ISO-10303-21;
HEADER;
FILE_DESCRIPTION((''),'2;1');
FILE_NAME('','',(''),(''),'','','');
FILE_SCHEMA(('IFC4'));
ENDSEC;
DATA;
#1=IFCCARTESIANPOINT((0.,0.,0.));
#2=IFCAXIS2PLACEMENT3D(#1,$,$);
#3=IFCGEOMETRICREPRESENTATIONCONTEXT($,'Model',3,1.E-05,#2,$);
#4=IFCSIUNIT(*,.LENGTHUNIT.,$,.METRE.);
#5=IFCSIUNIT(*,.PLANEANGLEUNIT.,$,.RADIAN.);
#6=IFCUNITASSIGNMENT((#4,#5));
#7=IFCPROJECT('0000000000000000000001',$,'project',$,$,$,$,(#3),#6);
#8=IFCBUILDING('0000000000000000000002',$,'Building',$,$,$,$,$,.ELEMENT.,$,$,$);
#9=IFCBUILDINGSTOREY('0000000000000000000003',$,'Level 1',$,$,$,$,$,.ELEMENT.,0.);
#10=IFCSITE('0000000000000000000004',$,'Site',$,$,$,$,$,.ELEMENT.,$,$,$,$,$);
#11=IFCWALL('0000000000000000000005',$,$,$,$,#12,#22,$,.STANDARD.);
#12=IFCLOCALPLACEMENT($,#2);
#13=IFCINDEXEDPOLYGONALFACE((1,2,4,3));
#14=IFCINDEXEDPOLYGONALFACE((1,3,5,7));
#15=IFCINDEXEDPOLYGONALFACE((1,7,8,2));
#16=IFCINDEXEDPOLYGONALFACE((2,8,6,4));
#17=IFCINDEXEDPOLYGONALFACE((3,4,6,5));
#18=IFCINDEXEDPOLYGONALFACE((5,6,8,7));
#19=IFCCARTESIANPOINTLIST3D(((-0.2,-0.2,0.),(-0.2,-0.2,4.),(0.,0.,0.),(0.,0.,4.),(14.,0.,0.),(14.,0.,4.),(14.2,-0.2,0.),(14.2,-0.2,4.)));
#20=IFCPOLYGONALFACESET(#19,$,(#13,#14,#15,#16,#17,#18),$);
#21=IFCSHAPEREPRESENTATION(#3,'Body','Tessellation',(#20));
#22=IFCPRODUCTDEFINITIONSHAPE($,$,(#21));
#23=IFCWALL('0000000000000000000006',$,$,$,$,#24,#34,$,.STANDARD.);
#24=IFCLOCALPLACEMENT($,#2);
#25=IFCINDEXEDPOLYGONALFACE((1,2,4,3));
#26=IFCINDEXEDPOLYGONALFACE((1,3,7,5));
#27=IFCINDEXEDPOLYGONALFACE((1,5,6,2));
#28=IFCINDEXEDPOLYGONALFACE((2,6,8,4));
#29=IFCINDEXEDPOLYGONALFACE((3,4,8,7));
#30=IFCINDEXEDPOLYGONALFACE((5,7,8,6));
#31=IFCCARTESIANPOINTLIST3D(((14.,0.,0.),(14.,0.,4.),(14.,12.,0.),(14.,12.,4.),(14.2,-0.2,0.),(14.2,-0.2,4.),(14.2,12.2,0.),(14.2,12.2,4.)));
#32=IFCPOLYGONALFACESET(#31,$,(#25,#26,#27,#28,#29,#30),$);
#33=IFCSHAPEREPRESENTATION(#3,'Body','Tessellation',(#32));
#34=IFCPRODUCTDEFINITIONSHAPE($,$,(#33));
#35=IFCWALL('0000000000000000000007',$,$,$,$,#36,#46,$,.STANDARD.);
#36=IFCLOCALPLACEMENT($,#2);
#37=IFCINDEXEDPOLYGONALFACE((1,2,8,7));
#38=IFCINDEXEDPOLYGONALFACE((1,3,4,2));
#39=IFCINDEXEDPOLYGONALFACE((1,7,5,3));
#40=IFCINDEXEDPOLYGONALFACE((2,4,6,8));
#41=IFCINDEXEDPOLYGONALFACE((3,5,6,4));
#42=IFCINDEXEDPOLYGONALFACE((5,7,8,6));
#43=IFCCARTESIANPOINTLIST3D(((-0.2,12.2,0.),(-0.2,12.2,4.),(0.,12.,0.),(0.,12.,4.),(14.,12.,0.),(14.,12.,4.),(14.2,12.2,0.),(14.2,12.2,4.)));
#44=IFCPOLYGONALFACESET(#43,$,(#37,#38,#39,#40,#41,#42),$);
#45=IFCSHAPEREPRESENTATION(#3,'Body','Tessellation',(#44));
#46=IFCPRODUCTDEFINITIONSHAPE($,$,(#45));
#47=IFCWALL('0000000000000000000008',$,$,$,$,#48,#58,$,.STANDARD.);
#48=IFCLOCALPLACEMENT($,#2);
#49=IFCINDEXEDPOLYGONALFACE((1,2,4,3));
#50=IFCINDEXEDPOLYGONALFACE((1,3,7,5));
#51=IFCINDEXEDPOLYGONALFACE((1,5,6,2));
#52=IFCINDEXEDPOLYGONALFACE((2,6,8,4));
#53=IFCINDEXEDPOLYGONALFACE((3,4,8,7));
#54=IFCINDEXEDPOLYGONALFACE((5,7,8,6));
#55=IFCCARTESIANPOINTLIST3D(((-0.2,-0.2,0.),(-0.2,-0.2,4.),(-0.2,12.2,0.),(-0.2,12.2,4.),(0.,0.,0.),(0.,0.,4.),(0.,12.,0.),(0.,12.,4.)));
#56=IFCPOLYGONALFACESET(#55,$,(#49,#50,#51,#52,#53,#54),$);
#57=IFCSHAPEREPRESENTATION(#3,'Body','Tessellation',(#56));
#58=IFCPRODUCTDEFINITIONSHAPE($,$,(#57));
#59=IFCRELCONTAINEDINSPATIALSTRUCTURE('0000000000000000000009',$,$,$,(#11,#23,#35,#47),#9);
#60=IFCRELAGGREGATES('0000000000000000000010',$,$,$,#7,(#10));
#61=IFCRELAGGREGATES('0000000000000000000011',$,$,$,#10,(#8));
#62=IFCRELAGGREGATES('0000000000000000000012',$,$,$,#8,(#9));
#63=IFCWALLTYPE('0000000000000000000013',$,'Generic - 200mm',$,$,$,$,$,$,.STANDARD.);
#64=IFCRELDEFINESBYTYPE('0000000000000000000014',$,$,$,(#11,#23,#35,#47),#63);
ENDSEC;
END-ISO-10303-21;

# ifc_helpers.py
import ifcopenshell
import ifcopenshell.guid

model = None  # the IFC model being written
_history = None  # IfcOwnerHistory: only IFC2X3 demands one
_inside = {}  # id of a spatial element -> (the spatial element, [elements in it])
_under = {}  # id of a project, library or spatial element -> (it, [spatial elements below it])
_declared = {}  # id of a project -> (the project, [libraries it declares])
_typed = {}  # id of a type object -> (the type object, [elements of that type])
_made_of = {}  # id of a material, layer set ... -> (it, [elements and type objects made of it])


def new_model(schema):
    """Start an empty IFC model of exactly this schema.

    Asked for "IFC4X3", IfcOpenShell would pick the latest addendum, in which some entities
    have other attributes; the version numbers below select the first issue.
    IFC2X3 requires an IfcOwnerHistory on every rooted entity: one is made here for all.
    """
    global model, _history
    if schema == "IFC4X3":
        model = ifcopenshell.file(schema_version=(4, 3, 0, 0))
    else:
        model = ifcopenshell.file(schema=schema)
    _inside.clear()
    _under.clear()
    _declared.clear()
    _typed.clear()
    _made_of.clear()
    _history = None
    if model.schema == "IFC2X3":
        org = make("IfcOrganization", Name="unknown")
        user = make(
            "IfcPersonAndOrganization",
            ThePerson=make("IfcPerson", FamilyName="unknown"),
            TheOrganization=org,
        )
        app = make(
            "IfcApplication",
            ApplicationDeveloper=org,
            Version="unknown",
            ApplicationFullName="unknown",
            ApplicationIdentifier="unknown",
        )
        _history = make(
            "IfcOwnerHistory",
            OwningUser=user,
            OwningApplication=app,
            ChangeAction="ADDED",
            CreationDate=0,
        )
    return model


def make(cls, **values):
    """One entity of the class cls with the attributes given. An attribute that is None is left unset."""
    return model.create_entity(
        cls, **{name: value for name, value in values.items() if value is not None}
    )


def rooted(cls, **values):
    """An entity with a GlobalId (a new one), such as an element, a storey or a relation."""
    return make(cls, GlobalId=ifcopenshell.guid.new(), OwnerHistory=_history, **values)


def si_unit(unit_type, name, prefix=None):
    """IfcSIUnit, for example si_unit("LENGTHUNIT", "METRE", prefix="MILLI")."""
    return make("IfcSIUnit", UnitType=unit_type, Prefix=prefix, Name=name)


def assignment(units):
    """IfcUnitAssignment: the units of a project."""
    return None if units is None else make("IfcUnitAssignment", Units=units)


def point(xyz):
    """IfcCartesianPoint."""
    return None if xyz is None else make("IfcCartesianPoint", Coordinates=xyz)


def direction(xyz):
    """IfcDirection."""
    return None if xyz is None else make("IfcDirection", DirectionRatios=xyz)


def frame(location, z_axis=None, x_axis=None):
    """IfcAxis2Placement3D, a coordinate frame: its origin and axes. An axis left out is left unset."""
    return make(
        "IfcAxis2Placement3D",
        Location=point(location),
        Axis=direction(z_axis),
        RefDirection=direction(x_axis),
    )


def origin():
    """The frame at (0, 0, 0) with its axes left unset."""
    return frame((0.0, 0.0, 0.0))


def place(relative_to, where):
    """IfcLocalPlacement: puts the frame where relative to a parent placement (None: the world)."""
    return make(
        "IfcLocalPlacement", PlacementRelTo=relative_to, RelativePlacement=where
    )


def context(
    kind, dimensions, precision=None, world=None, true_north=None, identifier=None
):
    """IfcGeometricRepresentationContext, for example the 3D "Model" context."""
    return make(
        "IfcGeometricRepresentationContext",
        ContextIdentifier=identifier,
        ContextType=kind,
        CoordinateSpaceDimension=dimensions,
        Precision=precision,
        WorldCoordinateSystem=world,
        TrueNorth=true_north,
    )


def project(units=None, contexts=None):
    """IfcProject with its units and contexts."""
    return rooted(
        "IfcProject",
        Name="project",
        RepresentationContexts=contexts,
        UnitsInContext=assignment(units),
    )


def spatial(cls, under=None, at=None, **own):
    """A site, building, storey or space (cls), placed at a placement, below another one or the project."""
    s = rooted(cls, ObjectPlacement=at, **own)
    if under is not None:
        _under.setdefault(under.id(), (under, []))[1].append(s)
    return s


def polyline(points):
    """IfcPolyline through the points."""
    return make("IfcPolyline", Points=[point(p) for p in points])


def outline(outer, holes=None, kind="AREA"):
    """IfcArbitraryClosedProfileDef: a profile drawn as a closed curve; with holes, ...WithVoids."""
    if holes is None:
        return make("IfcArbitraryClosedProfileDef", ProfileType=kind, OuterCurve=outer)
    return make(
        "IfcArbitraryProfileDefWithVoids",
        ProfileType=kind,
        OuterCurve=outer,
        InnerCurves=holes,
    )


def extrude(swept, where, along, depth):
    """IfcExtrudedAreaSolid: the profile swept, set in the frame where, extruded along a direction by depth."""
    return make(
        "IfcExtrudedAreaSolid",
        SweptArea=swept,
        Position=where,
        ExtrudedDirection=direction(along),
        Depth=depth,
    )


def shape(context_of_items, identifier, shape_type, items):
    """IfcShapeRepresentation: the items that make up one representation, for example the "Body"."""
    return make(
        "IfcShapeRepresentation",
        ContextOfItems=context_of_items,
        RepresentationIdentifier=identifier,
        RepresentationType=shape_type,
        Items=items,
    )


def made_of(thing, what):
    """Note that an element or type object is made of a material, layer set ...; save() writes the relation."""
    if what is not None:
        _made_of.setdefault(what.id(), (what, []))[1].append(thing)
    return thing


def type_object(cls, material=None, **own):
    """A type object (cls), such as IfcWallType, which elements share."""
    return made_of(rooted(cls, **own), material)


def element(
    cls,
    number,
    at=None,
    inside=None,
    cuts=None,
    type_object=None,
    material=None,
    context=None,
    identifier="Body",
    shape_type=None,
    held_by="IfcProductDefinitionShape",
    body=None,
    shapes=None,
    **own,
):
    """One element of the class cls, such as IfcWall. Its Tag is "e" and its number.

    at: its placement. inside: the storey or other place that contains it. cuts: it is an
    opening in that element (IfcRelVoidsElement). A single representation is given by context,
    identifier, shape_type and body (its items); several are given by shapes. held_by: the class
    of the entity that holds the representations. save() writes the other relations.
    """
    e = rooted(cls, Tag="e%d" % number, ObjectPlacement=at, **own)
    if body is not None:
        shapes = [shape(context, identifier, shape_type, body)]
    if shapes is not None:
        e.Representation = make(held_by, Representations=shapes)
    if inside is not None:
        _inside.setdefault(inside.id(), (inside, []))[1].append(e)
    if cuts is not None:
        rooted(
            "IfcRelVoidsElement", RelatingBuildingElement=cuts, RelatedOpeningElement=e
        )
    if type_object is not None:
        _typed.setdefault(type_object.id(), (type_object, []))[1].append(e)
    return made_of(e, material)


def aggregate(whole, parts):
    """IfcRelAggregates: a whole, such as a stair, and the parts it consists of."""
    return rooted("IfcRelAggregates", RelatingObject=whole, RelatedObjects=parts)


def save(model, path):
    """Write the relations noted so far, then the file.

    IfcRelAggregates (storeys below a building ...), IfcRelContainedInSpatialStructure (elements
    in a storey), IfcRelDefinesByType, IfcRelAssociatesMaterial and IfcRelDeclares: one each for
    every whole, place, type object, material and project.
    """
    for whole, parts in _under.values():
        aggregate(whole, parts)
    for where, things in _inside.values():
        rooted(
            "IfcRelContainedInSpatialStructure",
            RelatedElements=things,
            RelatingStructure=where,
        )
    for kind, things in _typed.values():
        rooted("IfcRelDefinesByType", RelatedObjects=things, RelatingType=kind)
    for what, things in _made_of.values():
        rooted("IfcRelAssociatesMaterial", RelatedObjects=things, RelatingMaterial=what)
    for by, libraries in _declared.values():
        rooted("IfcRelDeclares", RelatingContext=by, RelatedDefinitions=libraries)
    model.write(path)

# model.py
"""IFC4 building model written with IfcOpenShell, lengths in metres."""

from ifc_helpers import new_model, si_unit, frame, origin, place, context, project, spatial, polyline, outline, extrude, type_object, element, save


model = new_model("IFC4")

# Units and contexts
model_context = context("Model", 3, precision=1e-05, world=origin())
ifc_project = project(units=[si_unit("LENGTHUNIT", "METRE"), si_unit("PLANEANGLEUNIT", "RADIAN")], contexts=[model_context])

# Site, building, storey
site = spatial("IfcSite", under=ifc_project, Name="Site", CompositionType="ELEMENT")
building = spatial("IfcBuilding", under=site, Name="Building", CompositionType="ELEMENT")
storey = spatial("IfcBuildingStorey", under=building, Name="Level 1", CompositionType="ELEMENT", Elevation=0.0)

# Walls
wall_type = type_object("IfcWallType", Name="Generic - 200mm", PredefinedType="STANDARD")
wall_1_placement = place(None, frame((-0.1, -0.1, 0.0), z_axis=(0.0, 0.0, 1.0), x_axis=(1.0, 0.0, 0.0)))
element("IfcWall", 1, at=wall_1_placement, inside=storey, type_object=wall_type, PredefinedType="STANDARD", context=model_context, shape_type="SweptSolid", body=[
    extrude(outline(polyline([(-0.1, -0.1), (14.3, -0.1), (14.1, 0.1), (0.1, 0.1), (-0.1, -0.1)])), origin(), (0.0, 0.0, 1.0), 4.0),
])
wall_2_placement = place(None, frame((14.1, -0.1, 0.0), z_axis=(0.0, 0.0, 1.0), x_axis=(0.0, 1.0, 0.0)))
element("IfcWall", 2, at=wall_2_placement, inside=storey, type_object=wall_type, PredefinedType="STANDARD", context=model_context, shape_type="SweptSolid", body=[
    extrude(outline(polyline([(-0.1, -0.1), (12.3, -0.1), (12.1, 0.1), (0.1, 0.1), (-0.1, -0.1)])), origin(), (0.0, 0.0, 1.0), 4.0),
])
wall_3_placement = place(None, frame((14.1, 12.1, 0.0), z_axis=(0.0, 0.0, 1.0), x_axis=(-1.0, 0.0, 0.0)))
element("IfcWall", 3, at=wall_3_placement, inside=storey, type_object=wall_type, PredefinedType="STANDARD", context=model_context, shape_type="SweptSolid", body=[
    extrude(outline(polyline([(-0.1, -0.1), (14.3, -0.1), (14.1, 0.1), (0.1, 0.1), (-0.1, -0.1)])), origin(), (0.0, 0.0, 1.0), 4.0),
])
wall_4_placement = place(None, frame((-0.1, 12.1, 0.0), z_axis=(0.0, 0.0, 1.0), x_axis=(0.0, -1.0, 0.0)))
element("IfcWall", 4, at=wall_4_placement, inside=storey, type_object=wall_type, PredefinedType="STANDARD", context=model_context, shape_type="SweptSolid", body=[
    extrude(outline(polyline([(-0.1, -0.1), (12.3, -0.1), (12.1, 0.1), (0.1, 0.1), (-0.1, -0.1)])), origin(), (0.0, 0.0, 1.0), 4.0),
])

save(model, "model.ifc")
